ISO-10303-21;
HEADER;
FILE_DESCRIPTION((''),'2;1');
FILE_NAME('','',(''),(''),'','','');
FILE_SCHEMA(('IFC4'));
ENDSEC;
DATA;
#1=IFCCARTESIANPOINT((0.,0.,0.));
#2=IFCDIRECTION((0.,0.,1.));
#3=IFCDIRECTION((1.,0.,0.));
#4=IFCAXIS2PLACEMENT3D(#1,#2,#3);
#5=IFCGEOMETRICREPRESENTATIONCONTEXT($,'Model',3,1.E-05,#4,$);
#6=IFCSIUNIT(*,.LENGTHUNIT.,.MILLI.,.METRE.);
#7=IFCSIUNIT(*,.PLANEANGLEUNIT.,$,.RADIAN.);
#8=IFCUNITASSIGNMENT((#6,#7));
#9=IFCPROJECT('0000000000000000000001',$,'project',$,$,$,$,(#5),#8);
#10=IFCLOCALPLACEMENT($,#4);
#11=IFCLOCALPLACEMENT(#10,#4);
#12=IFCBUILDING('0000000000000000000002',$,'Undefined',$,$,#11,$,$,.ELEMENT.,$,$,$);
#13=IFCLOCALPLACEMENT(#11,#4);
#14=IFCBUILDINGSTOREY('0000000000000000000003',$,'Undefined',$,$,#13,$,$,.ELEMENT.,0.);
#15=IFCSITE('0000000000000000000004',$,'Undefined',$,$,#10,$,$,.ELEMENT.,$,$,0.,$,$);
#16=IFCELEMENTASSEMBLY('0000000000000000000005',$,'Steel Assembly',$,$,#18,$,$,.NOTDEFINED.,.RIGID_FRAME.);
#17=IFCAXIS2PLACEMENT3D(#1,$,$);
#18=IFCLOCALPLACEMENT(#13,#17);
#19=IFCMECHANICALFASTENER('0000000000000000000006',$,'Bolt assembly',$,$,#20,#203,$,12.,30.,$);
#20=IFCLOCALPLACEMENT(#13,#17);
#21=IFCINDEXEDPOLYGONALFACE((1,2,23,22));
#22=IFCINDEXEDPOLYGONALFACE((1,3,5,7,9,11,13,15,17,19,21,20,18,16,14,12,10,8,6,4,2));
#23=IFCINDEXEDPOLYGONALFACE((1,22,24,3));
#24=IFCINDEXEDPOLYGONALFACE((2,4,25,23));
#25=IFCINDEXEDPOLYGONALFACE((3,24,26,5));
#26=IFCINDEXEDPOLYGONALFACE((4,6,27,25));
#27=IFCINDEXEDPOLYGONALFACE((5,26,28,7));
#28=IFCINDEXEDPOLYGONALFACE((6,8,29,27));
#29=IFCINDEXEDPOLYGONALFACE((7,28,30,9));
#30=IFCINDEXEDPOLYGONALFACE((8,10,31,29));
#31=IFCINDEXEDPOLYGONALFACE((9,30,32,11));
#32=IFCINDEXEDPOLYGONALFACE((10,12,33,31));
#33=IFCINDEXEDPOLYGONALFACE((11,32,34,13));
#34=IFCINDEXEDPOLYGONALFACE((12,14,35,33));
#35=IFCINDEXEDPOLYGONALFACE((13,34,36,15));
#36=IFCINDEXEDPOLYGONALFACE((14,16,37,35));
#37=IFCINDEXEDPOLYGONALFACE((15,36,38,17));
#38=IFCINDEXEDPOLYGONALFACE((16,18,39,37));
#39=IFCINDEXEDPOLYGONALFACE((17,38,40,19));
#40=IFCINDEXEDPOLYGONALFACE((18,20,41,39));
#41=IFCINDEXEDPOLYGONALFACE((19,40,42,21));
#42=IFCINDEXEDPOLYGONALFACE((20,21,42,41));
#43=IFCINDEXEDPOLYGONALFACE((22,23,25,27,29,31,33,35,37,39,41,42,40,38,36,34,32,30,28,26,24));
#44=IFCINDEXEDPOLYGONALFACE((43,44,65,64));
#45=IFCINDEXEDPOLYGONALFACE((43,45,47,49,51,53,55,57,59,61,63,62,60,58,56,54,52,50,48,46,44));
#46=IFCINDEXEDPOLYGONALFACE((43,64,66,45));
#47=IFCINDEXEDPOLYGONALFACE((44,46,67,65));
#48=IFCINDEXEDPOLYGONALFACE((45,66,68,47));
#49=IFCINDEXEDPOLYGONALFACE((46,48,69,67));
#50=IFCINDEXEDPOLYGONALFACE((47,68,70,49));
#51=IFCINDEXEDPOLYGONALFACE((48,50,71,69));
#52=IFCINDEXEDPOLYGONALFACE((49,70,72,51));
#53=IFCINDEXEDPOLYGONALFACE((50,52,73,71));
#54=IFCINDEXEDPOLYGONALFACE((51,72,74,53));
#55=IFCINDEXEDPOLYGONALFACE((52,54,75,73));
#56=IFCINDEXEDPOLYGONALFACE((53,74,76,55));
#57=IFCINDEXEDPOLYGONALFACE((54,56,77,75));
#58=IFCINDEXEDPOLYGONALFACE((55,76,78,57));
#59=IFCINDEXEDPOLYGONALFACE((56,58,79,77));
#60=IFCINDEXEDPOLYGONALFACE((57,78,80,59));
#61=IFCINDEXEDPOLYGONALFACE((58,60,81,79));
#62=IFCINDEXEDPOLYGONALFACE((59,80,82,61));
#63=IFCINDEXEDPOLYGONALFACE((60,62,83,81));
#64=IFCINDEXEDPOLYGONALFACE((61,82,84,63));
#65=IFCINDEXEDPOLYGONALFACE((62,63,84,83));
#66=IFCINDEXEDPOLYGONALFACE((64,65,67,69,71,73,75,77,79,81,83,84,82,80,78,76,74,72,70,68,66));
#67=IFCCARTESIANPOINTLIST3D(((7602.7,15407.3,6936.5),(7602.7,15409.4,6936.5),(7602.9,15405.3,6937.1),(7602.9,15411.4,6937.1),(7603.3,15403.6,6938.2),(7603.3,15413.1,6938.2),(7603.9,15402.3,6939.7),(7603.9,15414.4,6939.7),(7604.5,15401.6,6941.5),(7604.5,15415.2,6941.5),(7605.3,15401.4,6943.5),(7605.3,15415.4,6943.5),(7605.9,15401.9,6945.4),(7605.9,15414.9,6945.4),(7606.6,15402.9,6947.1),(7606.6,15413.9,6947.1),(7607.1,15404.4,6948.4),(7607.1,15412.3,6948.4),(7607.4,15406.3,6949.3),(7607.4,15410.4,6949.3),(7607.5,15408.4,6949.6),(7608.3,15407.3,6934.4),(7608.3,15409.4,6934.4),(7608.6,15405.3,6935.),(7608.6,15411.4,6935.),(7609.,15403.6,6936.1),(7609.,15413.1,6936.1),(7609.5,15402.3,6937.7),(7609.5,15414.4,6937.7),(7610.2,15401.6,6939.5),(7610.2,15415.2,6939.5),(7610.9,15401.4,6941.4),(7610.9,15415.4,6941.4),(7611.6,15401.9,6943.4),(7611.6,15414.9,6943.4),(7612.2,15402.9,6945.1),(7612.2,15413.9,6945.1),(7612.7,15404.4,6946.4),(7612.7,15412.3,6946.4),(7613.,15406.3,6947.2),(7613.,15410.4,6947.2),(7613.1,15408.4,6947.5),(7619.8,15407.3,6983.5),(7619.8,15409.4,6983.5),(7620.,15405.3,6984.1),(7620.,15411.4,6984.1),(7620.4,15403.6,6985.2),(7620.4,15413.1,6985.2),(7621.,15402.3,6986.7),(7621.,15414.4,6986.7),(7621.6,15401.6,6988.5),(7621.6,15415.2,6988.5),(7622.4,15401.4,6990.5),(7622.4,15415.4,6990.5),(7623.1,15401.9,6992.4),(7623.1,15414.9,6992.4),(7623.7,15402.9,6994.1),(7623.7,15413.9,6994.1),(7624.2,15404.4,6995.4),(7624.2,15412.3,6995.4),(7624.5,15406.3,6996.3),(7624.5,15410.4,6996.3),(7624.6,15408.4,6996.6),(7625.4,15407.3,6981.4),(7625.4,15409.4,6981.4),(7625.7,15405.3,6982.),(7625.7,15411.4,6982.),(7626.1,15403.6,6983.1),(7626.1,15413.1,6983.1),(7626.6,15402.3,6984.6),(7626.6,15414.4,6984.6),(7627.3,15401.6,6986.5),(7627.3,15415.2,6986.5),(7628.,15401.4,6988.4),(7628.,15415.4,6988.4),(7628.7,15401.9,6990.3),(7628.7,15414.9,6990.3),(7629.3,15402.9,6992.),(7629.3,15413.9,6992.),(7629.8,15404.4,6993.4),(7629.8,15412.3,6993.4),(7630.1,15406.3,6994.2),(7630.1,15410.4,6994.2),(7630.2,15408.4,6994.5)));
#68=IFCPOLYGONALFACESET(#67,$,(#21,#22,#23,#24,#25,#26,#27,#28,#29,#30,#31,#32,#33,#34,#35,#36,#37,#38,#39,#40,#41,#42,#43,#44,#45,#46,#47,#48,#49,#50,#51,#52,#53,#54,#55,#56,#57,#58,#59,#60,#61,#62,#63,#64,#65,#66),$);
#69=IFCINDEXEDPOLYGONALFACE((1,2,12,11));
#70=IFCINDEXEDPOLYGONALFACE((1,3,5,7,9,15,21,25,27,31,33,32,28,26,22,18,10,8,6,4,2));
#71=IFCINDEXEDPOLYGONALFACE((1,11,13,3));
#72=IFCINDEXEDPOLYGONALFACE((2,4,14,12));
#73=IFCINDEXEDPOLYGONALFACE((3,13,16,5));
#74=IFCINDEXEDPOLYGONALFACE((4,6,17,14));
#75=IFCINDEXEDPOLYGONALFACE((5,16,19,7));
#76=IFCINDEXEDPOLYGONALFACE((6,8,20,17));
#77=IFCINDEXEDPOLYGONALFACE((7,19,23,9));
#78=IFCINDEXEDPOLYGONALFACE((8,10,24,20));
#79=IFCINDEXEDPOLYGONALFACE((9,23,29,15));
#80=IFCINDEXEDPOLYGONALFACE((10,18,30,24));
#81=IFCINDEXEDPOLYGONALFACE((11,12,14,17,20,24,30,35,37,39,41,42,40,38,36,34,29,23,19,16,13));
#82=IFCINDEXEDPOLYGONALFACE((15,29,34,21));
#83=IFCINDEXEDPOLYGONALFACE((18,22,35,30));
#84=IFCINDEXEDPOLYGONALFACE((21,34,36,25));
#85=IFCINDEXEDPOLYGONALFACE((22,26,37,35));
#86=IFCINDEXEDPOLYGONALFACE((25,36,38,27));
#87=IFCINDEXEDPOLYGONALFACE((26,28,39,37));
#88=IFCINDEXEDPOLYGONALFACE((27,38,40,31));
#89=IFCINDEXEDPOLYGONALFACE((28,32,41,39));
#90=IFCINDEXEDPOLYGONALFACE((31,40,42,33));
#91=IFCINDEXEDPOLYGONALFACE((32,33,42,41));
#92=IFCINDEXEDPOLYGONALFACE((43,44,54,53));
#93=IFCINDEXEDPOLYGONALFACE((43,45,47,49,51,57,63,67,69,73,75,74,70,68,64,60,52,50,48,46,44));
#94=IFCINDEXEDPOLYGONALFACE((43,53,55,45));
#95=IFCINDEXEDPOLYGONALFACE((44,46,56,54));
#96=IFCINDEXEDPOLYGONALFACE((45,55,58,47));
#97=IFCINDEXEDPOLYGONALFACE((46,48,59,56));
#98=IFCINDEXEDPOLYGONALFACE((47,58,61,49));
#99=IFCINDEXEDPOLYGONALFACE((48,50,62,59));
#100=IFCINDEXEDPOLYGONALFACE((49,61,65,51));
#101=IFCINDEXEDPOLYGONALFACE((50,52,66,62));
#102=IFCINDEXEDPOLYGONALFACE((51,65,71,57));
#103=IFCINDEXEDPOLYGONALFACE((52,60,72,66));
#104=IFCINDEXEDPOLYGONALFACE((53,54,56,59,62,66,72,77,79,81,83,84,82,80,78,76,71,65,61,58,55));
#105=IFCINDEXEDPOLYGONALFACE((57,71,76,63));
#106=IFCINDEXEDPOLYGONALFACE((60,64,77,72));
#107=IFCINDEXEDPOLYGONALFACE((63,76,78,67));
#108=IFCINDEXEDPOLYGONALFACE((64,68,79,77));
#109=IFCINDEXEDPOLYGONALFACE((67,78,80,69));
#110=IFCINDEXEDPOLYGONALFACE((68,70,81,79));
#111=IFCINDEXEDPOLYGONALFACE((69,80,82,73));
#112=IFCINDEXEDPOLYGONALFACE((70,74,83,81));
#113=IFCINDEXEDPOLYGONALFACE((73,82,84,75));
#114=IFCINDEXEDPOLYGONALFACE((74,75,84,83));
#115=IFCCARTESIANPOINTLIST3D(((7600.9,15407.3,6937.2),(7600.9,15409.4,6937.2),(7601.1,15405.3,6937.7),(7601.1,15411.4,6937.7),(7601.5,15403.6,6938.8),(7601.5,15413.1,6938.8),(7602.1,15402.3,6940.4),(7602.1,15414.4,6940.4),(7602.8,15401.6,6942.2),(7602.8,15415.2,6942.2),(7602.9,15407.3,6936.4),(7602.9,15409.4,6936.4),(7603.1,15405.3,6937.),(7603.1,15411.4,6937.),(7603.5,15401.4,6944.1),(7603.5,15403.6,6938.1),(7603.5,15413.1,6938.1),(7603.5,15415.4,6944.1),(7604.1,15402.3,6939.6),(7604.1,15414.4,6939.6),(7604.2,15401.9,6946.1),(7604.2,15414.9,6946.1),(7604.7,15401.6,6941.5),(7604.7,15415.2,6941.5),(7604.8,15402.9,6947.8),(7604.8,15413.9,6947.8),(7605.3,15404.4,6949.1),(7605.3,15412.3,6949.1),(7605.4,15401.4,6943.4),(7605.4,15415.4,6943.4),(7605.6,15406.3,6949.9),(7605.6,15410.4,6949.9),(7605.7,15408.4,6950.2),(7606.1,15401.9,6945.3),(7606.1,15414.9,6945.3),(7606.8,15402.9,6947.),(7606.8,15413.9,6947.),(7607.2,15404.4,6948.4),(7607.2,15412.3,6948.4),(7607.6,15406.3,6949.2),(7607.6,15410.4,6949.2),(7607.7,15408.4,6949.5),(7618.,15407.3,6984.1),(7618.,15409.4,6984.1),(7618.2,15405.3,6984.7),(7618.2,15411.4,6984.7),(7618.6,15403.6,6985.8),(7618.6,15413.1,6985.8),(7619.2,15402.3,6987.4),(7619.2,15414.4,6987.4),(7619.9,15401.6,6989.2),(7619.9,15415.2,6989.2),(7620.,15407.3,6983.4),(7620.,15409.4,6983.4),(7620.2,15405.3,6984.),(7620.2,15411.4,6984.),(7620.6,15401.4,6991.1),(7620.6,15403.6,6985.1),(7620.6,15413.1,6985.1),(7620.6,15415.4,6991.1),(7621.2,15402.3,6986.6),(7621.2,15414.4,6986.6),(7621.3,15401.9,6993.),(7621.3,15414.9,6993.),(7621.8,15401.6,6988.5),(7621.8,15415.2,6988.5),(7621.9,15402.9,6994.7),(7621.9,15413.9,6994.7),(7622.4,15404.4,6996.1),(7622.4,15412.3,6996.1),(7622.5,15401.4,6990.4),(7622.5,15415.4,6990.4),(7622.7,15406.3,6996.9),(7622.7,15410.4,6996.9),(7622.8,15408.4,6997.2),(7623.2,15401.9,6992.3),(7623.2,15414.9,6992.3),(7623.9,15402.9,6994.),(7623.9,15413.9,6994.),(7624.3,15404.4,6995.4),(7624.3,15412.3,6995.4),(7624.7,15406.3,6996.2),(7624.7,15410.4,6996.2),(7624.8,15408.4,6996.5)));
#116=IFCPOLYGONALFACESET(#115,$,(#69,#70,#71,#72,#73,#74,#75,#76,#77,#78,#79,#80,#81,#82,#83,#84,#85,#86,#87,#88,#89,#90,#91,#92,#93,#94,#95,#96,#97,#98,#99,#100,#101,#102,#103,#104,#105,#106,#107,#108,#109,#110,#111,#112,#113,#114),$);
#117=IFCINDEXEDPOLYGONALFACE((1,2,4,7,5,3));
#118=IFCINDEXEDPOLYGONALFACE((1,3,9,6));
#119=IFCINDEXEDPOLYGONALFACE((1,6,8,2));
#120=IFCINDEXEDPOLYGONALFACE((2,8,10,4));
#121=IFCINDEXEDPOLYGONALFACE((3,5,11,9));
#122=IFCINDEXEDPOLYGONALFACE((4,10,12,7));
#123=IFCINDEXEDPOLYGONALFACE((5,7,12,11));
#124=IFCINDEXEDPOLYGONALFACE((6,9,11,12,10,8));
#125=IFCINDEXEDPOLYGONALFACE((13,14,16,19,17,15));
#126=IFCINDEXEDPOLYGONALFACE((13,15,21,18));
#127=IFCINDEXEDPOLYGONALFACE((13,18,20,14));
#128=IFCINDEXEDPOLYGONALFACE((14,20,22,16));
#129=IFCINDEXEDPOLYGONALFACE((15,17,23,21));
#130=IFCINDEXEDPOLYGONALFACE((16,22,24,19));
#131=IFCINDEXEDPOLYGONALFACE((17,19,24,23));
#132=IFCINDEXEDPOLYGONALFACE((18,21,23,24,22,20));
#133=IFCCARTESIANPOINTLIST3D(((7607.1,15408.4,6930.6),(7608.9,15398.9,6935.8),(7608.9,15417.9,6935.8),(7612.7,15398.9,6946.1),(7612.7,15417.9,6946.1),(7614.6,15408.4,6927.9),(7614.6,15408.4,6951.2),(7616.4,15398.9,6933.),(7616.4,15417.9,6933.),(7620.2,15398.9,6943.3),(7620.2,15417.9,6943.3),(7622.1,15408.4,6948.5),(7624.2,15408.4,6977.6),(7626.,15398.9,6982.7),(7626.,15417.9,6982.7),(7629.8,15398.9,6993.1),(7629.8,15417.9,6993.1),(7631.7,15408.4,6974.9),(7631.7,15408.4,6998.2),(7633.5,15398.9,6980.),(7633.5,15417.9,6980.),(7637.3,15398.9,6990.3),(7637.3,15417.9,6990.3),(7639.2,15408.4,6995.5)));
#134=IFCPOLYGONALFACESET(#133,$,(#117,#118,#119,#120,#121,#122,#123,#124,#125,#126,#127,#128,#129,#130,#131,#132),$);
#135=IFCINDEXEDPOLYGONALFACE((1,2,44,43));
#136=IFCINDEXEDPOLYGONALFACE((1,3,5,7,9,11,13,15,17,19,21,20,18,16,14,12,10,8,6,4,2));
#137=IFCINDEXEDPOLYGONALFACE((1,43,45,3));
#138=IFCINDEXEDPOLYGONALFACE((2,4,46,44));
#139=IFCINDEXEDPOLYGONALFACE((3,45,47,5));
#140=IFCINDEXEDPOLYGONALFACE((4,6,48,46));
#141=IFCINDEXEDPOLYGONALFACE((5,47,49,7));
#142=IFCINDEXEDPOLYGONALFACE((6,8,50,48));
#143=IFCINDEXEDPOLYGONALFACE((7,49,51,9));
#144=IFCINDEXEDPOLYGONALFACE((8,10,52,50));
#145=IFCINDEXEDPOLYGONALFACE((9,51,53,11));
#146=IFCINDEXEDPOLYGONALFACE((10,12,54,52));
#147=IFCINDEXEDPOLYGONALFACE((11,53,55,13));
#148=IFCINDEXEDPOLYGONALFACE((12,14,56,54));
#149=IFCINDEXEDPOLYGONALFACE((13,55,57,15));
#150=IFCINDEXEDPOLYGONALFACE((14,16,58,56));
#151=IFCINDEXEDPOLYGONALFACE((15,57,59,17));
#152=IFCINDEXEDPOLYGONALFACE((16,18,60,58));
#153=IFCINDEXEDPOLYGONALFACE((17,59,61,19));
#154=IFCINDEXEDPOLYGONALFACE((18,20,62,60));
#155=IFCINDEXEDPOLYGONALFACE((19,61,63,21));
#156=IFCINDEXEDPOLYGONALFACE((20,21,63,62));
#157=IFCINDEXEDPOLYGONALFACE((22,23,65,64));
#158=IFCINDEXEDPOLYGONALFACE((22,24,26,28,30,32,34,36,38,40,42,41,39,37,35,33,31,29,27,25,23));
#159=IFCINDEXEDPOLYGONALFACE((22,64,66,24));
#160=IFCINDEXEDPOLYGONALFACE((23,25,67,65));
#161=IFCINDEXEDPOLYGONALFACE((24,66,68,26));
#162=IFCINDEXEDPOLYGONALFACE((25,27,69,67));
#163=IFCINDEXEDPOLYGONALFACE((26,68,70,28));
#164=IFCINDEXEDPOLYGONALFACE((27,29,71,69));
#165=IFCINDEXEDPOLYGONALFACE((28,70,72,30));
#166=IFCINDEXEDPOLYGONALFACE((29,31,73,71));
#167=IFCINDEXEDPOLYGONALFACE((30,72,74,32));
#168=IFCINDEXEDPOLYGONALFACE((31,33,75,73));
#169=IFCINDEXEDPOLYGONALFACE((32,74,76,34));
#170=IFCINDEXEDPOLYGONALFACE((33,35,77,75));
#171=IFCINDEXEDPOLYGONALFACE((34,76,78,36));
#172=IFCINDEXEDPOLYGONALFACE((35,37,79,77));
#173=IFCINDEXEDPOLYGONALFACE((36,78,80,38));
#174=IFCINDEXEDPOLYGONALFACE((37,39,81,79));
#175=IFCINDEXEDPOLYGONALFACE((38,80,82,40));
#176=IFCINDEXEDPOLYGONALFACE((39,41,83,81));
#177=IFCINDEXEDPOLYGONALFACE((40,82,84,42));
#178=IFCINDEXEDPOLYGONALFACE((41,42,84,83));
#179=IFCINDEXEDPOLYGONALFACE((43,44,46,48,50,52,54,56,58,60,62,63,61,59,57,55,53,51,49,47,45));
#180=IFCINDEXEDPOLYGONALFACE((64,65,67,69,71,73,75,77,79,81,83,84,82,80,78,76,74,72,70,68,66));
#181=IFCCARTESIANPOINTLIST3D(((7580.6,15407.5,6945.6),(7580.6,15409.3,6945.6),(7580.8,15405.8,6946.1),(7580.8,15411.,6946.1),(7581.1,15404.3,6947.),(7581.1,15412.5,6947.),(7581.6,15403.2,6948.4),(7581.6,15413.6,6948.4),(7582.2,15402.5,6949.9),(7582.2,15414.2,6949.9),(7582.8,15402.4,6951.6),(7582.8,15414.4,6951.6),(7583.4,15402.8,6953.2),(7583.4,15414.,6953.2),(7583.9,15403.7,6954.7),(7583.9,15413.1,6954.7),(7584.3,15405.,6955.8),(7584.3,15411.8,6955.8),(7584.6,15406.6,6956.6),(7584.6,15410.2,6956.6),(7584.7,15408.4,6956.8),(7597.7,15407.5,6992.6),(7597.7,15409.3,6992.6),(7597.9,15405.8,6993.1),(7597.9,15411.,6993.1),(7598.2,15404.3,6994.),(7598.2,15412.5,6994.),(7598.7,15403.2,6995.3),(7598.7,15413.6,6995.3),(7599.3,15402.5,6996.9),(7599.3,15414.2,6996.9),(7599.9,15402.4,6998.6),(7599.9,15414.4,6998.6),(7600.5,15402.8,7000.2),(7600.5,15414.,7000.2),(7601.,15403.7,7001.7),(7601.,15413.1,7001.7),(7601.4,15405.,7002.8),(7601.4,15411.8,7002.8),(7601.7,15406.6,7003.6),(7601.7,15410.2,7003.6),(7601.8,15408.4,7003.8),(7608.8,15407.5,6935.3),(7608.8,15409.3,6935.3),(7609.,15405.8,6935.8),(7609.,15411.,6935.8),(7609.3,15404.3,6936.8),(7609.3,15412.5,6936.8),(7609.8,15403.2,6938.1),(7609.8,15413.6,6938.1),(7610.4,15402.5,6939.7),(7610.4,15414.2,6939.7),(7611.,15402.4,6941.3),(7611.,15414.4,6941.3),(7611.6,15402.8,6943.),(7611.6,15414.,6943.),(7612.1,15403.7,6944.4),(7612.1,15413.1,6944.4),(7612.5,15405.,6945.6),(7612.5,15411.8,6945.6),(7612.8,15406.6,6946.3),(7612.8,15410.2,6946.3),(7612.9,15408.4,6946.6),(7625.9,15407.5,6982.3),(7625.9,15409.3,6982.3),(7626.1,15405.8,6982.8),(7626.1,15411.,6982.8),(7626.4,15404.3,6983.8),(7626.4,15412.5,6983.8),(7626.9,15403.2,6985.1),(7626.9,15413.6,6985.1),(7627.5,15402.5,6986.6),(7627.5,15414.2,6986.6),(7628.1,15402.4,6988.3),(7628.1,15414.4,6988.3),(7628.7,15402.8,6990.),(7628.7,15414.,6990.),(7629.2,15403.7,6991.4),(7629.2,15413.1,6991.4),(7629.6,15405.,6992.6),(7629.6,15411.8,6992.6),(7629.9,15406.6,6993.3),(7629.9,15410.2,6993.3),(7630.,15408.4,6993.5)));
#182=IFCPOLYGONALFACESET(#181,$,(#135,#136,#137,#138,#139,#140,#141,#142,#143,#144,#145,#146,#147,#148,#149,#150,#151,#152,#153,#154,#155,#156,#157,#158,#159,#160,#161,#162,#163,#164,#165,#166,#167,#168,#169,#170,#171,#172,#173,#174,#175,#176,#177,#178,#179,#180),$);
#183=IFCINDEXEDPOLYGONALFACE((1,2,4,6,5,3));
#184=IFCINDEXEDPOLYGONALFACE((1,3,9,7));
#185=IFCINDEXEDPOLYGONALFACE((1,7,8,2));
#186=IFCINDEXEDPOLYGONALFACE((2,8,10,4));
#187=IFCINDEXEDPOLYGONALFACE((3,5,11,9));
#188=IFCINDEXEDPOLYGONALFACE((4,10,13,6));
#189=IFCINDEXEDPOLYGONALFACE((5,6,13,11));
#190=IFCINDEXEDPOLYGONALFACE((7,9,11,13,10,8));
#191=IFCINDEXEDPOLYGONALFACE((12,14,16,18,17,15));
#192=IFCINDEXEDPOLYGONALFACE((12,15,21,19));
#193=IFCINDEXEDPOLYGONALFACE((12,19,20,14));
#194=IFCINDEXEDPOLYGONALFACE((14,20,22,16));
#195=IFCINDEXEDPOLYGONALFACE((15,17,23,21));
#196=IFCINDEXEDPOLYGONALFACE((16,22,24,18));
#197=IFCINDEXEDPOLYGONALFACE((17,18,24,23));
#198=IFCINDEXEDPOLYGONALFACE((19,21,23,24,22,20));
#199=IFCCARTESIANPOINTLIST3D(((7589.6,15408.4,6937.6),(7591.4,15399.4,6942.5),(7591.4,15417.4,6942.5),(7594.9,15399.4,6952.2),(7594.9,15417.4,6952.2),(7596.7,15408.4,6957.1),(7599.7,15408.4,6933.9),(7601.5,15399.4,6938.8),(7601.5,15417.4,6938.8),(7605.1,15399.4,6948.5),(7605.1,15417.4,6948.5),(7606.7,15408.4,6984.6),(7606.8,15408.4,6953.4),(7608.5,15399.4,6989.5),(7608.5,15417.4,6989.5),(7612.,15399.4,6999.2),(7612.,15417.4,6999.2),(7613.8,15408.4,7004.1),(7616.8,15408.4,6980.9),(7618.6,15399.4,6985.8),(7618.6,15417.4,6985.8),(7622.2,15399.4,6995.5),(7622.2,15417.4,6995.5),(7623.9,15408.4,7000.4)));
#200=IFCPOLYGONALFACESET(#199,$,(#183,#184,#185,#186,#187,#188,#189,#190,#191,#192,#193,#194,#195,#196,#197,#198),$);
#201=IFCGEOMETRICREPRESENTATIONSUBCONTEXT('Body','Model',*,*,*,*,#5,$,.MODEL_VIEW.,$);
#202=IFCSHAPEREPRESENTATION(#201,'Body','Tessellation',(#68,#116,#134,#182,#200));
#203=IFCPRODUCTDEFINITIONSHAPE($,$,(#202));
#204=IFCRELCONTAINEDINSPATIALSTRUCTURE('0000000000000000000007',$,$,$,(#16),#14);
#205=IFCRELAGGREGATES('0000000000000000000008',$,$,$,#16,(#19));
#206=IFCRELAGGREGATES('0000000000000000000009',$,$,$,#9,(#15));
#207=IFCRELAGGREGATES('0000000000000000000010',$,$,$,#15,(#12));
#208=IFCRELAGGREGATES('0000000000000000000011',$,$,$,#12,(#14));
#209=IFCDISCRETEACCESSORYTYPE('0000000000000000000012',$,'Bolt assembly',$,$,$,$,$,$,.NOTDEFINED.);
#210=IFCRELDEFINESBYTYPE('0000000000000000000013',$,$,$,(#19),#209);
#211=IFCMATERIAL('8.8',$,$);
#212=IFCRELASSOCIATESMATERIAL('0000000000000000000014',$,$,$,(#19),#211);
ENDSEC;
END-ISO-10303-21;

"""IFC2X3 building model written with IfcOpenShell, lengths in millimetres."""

from ifc_helpers import new_model, si_unit, frame, origin_with_axes, origin_2d_with_axis, place, context, subcontext, project, spatial, polyline, circle, outline, extrude, source, transform, mapped, material, type_object, element, aggregate, save


model = new_model("IFC2X3")

# Units and contexts
model_context = context("Model", 3, precision=1e-05, world=origin_with_axes())
body_context = subcontext(model_context, "Body", "Model", "MODEL_VIEW")
ifc_project = project(units=[si_unit("LENGTHUNIT", "METRE", prefix="MILLI"), si_unit("PLANEANGLEUNIT", "RADIAN")], contexts=[model_context])

# Site, building, storey
site_placement = place(None, origin_with_axes())
site = spatial("IfcSite", under=ifc_project, at=site_placement, Name="Undefined", CompositionType="ELEMENT", RefElevation=0.0)
building_placement = place(site_placement, origin_with_axes())
building = spatial("IfcBuilding", under=site, at=building_placement, Name="Undefined", CompositionType="ELEMENT")
storey_placement = place(building_placement, origin_with_axes())
storey = spatial("IfcBuildingStorey", under=building, at=storey_placement, Name="Undefined", CompositionType="ELEMENT", Elevation=0.0)

# Element assembly
assembly_1_placement = place(storey_placement, origin_with_axes())
assembly_1 = element("IfcElementAssembly", 1, at=assembly_1_placement, inside=storey, Name="Steel Assembly", AssemblyPlace="NOTDEFINED", PredefinedType="RIGID_FRAME")

# Shared definitions
ifc_material_1 = material(Name="8.8")
discrete_accessory_type_1 = type_object("IfcDiscreteAccessoryType", Name="Bolt assembly")
shared_shape_1 = source(origin_with_axes(), body_context, "Body", "SweptSolid", [
    extrude(circle(Radius=7.0, at=origin_2d_with_axis()), frame((0.0, -5.9, 0.0), z_axis=(0.0, 1.0, 0.0), x_axis=(1.0, 0.0, 0.0)), (0.0, 0.0, 1.0), 6.0),
    extrude(circle(Radius=7.0, at=origin_2d_with_axis()), frame((0.0, -0.1, 0.0), z_axis=(0.0, 1.0, 0.0), x_axis=(1.0, 0.0, 0.0)), (0.0, 0.0, 1.0), 2.1),
    extrude(outline(polyline([(11.0, 0.0), (5.5, 9.5), (-5.5, 9.5), (-11.0, 0.0), (-5.5, -9.5), (5.5, -9.5), (11.0, 0.0)])), frame((0.0, -14.0, 0.0), z_axis=(0.0, 1.0, 0.0), x_axis=(1.0, 0.0, 0.0)), (0.0, 0.0, 1.0), 8.0),
    extrude(circle(Radius=6.0, at=origin_2d_with_axis()), frame((0.0, -6.0, 0.0), z_axis=(0.0, 1.0, 0.0), x_axis=(1.0, 0.0, 0.0)), (0.0, 0.0, 1.0), 30.0),
    extrude(outline(polyline([(10.4, 0.0), (5.2, 9.0), (-5.2, 9.0), (-10.4, 0.0), (-5.2, -9.0), (5.2, -9.0), (10.4, 0.0)])), frame((0.0, 2.0, 0.0), z_axis=(0.0, 1.0, 0.0), x_axis=(1.0, 0.0, 0.0)), (0.0, 0.0, 1.0), 10.8),
])

# Mechanical fastener
mechanical_fastener_1_placement = place(assembly_1_placement, frame((7605.2, 15408.4, 6943.0), z_axis=(0.0, -1.0, 0.0), x_axis=(0.34202, 0.0, 0.939693)))
mechanical_fastener_1 = element("IfcMechanicalFastener", 2, at=mechanical_fastener_1_placement, type_object=discrete_accessory_type_1, material=ifc_material_1, Name="Bolt assembly", NominalDiameter=12.0, NominalLength=30.0, context=body_context, shape_type="MappedRepresentation", body=[
    mapped(shared_shape_1, transform((0.0, 0.0, 0.0))),
    mapped(shared_shape_1, transform((50.0, 0.0, 0.0))),
])
aggregate(assembly_1, [mechanical_fastener_1])

save(model, "model.ifc")
